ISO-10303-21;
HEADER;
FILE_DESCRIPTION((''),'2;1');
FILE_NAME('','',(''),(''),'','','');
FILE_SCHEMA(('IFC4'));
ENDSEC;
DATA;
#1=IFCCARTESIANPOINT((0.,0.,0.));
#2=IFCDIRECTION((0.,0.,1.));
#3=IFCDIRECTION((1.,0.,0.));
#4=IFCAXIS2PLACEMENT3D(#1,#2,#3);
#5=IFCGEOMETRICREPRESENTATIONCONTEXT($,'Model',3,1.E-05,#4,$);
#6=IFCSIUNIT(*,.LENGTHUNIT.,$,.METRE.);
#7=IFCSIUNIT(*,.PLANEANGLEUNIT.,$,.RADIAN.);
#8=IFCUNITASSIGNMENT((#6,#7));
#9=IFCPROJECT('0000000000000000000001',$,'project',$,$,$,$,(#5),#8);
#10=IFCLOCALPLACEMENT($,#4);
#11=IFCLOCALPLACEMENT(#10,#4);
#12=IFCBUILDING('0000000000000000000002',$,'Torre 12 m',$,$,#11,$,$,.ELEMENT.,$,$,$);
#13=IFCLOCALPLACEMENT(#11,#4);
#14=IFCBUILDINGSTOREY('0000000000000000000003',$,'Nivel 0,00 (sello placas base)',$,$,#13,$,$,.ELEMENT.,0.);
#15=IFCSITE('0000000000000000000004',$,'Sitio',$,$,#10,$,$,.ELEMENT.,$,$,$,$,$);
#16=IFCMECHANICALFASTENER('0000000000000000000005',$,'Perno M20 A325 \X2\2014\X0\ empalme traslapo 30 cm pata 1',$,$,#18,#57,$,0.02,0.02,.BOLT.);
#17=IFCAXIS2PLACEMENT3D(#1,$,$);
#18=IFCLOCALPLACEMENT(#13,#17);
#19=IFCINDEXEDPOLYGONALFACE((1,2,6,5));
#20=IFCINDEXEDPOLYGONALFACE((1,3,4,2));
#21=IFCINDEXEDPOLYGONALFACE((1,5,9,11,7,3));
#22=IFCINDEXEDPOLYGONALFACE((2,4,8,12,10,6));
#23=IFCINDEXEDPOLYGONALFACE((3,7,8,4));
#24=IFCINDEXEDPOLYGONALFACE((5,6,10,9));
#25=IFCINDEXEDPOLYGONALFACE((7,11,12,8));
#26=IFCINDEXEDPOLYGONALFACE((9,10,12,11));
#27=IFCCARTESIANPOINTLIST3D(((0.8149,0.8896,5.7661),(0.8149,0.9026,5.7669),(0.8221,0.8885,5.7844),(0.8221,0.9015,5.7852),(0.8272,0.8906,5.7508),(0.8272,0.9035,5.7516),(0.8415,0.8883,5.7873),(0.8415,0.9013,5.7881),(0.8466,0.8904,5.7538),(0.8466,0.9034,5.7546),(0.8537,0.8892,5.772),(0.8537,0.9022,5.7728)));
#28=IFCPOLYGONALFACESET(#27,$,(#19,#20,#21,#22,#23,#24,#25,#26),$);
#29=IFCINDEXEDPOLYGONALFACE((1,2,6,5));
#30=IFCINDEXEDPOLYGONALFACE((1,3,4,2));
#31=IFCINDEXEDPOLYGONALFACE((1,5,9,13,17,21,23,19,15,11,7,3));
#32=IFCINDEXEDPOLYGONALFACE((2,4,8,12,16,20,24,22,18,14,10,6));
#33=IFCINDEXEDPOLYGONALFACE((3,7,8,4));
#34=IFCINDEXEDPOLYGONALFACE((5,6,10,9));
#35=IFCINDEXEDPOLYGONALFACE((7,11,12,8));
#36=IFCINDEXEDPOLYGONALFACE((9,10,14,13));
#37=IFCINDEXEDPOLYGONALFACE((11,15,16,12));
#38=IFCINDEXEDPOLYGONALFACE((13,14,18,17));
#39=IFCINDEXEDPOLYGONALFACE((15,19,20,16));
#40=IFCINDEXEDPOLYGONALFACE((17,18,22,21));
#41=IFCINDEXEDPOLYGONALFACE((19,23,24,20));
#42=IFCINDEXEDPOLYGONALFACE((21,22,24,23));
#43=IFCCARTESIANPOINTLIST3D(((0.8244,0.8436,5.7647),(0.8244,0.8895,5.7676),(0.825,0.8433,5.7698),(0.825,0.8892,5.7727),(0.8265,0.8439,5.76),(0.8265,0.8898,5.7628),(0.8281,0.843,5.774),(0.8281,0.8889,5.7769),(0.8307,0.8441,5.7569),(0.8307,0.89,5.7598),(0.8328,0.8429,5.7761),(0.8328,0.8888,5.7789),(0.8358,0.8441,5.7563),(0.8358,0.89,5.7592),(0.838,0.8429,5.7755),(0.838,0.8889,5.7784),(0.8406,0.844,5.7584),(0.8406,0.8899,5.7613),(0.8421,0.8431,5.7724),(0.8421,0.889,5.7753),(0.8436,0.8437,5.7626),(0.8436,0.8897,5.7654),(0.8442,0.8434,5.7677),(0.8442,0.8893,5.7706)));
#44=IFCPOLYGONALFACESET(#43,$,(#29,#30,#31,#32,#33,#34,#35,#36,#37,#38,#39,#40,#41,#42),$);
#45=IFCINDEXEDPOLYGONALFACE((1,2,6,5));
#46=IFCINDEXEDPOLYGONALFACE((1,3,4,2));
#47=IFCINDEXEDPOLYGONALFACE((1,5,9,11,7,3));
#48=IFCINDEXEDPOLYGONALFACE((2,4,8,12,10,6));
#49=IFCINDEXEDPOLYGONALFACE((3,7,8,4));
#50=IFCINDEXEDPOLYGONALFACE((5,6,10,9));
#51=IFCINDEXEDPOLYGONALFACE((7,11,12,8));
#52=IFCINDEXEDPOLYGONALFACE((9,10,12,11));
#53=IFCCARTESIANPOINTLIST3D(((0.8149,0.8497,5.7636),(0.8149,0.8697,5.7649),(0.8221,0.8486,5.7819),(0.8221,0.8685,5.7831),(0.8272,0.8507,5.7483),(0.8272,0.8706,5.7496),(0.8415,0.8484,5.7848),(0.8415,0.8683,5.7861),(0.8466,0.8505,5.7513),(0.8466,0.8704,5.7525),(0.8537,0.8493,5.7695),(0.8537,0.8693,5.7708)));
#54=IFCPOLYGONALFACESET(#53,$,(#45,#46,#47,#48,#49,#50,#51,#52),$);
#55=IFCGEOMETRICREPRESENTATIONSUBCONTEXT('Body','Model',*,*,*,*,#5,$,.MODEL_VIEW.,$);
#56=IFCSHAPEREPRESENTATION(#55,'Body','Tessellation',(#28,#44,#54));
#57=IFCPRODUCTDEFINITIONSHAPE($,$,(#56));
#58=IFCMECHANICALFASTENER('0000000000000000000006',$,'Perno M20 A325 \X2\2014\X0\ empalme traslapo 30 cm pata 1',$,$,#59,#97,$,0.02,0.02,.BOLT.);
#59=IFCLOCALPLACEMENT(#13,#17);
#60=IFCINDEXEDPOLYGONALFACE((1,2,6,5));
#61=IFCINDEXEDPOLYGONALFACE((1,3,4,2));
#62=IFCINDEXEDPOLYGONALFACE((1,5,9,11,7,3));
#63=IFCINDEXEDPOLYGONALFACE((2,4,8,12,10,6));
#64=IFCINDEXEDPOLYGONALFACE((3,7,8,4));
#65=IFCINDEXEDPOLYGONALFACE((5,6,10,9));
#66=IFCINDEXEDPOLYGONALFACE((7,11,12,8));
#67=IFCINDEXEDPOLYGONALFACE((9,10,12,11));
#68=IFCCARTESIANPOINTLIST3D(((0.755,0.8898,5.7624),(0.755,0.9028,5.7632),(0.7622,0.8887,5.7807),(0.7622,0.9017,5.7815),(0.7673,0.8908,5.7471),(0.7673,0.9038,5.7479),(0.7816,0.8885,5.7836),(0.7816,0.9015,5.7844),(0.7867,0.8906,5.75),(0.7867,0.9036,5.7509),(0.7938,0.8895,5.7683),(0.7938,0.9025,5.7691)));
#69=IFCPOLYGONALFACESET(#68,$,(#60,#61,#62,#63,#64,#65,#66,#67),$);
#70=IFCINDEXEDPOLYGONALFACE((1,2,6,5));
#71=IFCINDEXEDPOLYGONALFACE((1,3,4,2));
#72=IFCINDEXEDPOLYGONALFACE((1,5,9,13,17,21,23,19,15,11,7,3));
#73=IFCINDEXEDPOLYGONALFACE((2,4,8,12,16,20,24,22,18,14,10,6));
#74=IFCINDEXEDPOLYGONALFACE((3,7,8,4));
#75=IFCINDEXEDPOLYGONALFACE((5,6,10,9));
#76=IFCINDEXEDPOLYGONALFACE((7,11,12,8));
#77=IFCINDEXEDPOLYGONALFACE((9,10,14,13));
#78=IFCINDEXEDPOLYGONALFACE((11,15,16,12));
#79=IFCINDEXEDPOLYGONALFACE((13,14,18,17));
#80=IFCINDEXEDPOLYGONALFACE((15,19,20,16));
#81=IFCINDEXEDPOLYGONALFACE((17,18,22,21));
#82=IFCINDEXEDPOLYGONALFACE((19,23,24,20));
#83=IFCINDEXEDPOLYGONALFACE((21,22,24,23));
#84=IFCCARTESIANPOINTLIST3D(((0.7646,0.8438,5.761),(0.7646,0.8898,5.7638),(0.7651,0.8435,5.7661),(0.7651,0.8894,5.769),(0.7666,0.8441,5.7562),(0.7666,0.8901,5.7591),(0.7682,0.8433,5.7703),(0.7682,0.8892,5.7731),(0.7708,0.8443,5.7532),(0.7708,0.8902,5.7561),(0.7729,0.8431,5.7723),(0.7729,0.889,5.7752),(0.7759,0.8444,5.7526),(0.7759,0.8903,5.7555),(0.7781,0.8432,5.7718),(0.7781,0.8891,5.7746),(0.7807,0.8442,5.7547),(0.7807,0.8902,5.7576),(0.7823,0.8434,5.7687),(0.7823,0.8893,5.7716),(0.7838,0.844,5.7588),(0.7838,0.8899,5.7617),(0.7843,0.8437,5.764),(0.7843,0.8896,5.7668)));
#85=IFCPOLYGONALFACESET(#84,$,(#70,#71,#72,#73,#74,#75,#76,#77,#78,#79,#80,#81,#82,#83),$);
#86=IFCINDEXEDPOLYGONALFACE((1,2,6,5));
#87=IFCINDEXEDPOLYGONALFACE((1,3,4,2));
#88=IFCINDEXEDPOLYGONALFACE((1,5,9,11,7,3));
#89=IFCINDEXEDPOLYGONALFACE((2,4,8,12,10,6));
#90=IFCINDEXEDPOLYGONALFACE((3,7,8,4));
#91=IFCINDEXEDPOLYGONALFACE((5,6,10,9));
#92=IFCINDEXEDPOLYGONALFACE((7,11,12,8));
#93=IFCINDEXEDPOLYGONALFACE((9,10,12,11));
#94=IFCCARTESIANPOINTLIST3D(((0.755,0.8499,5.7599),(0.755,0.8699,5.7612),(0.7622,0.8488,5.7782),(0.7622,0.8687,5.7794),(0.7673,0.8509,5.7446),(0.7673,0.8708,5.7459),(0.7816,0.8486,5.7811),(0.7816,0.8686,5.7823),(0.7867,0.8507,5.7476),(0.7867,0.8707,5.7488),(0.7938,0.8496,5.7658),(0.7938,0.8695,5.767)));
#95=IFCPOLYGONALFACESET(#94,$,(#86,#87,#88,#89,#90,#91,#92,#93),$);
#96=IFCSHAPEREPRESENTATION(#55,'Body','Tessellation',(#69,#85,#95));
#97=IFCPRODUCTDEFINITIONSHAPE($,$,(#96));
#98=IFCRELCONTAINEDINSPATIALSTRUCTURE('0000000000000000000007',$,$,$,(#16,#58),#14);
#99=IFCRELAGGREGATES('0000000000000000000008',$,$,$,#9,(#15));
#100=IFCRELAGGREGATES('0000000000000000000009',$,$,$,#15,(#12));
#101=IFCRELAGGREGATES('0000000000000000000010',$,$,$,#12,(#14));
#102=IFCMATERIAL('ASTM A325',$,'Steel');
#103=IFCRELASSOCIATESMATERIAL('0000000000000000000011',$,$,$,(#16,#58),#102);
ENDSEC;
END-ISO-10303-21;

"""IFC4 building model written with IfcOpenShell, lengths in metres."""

from ifc_helpers import new_model, si_unit, frame, origin_with_axes, place, context, subcontext, project, spatial, polyline, outline, extrude, material, element, save


model = new_model("IFC4")

# Units and contexts
model_context = context("Model", 3, precision=1e-05, world=origin_with_axes())
body_context = subcontext(model_context, "Body", "Model", "MODEL_VIEW")
ifc_project = project(units=[si_unit("LENGTHUNIT", "METRE"), si_unit("PLANEANGLEUNIT", "RADIAN")], contexts=[model_context])

# Site, building, storey
site_placement = place(None, origin_with_axes())
site = spatial("IfcSite", under=ifc_project, at=site_placement, Name="Sitio", CompositionType="ELEMENT")
building_placement = place(site_placement, origin_with_axes())
building = spatial("IfcBuilding", under=site, at=building_placement, Name="Torre 12 m", CompositionType="ELEMENT")
storey_placement = place(building_placement, origin_with_axes())
storey = spatial("IfcBuildingStorey", under=building, at=storey_placement, Name="Nivel 0,00 (sello placas base)", CompositionType="ELEMENT", Elevation=0.0)

# Shared definitions
placement = place(storey_placement, origin_with_axes())

# Mechanical fasteners
ifc_material_1 = material(Name="ASTM A325", Category="Steel")
element("IfcMechanicalFastener", 1, at=placement, inside=storey, material=ifc_material_1, Name="Perno M20 A325 — empalme traslapo 30 cm pata 1", NominalDiameter=0.02, NominalLength=0.02, PredefinedType="BOLT", context=body_context, shape_type="SweptSolid", body=[
    extrude(outline(polyline([(0.017, 0.0098), (0.0, 0.0196), (-0.017, 0.0098), (-0.017, -0.0098), (0.0, -0.0196), (0.017, -0.0098), (0.017, 0.0098)])), frame((0.8343, 0.9024, 5.7699), z_axis=(0.0, -0.998053, -0.062378), x_axis=(-0.931337, -0.022716, 0.363449)), (0.0, 0.0, 1.0), 0.013),
    extrude(outline(polyline([(0.01, 0.0), (0.0087, 0.005), (0.005, 0.0087), (0.0, 0.01), (-0.005, 0.0087), (-0.0087, 0.005), (-0.01, 0.0), (-0.0087, -0.005), (-0.005, -0.0087), (0.0, -0.01), (0.005, -0.0087), (0.0087, -0.005), (0.01, 0.0)])), frame((0.8343, 0.8894, 5.7691), z_axis=(0.0, -0.998053, -0.062378), x_axis=(-0.931337, -0.022716, 0.363449)), (0.0, 0.0, 1.0), 0.046),
    extrude(outline(polyline([(0.017, 0.0098), (0.0, 0.0196), (-0.017, 0.0098), (-0.017, -0.0098), (0.0, -0.0196), (0.017, -0.0098), (0.017, 0.0098)])), frame((0.8343, 0.8695, 5.7678), z_axis=(0.0, -0.998053, -0.062378), x_axis=(-0.931337, -0.022716, 0.363449)), (0.0, 0.0, 1.0), 0.02),
])
element("IfcMechanicalFastener", 2, at=placement, inside=storey, material=ifc_material_1, Name="Perno M20 A325 — empalme traslapo 30 cm pata 1", NominalDiameter=0.02, NominalLength=0.02, PredefinedType="BOLT", context=body_context, shape_type="SweptSolid", body=[
    extrude(outline(polyline([(0.017, 0.0098), (0.0, 0.0196), (-0.017, 0.0098), (-0.017, -0.0098), (0.0, -0.0196), (0.017, -0.0098), (0.017, 0.0098)])), frame((0.7744, 0.9026, 5.7662), z_axis=(0.0, -0.998053, -0.062378), x_axis=(-0.931337, -0.022716, 0.363449)), (0.0, 0.0, 1.0), 0.013),
    extrude(outline(polyline([(0.01, 0.0), (0.0087, 0.005), (0.005, 0.0087), (0.0, 0.01), (-0.005, 0.0087), (-0.0087, 0.005), (-0.01, 0.0), (-0.0087, -0.005), (-0.005, -0.0087), (0.0, -0.01), (0.005, -0.0087), (0.0087, -0.005), (0.01, 0.0)])), frame((0.7744, 0.8897, 5.7653), z_axis=(0.0, -0.998053, -0.062378), x_axis=(-0.931337, -0.022716, 0.363449)), (0.0, 0.0, 1.0), 0.046),
    extrude(outline(polyline([(0.017, 0.0098), (0.0, 0.0196), (-0.017, 0.0098), (-0.017, -0.0098), (0.0, -0.0196), (0.017, -0.0098), (0.017, 0.0098)])), frame((0.7744, 0.8697, 5.7641), z_axis=(0.0, -0.998053, -0.062378), x_axis=(-0.931337, -0.022716, 0.363449)), (0.0, 0.0, 1.0), 0.02),
])

save(model, "model.ifc")
